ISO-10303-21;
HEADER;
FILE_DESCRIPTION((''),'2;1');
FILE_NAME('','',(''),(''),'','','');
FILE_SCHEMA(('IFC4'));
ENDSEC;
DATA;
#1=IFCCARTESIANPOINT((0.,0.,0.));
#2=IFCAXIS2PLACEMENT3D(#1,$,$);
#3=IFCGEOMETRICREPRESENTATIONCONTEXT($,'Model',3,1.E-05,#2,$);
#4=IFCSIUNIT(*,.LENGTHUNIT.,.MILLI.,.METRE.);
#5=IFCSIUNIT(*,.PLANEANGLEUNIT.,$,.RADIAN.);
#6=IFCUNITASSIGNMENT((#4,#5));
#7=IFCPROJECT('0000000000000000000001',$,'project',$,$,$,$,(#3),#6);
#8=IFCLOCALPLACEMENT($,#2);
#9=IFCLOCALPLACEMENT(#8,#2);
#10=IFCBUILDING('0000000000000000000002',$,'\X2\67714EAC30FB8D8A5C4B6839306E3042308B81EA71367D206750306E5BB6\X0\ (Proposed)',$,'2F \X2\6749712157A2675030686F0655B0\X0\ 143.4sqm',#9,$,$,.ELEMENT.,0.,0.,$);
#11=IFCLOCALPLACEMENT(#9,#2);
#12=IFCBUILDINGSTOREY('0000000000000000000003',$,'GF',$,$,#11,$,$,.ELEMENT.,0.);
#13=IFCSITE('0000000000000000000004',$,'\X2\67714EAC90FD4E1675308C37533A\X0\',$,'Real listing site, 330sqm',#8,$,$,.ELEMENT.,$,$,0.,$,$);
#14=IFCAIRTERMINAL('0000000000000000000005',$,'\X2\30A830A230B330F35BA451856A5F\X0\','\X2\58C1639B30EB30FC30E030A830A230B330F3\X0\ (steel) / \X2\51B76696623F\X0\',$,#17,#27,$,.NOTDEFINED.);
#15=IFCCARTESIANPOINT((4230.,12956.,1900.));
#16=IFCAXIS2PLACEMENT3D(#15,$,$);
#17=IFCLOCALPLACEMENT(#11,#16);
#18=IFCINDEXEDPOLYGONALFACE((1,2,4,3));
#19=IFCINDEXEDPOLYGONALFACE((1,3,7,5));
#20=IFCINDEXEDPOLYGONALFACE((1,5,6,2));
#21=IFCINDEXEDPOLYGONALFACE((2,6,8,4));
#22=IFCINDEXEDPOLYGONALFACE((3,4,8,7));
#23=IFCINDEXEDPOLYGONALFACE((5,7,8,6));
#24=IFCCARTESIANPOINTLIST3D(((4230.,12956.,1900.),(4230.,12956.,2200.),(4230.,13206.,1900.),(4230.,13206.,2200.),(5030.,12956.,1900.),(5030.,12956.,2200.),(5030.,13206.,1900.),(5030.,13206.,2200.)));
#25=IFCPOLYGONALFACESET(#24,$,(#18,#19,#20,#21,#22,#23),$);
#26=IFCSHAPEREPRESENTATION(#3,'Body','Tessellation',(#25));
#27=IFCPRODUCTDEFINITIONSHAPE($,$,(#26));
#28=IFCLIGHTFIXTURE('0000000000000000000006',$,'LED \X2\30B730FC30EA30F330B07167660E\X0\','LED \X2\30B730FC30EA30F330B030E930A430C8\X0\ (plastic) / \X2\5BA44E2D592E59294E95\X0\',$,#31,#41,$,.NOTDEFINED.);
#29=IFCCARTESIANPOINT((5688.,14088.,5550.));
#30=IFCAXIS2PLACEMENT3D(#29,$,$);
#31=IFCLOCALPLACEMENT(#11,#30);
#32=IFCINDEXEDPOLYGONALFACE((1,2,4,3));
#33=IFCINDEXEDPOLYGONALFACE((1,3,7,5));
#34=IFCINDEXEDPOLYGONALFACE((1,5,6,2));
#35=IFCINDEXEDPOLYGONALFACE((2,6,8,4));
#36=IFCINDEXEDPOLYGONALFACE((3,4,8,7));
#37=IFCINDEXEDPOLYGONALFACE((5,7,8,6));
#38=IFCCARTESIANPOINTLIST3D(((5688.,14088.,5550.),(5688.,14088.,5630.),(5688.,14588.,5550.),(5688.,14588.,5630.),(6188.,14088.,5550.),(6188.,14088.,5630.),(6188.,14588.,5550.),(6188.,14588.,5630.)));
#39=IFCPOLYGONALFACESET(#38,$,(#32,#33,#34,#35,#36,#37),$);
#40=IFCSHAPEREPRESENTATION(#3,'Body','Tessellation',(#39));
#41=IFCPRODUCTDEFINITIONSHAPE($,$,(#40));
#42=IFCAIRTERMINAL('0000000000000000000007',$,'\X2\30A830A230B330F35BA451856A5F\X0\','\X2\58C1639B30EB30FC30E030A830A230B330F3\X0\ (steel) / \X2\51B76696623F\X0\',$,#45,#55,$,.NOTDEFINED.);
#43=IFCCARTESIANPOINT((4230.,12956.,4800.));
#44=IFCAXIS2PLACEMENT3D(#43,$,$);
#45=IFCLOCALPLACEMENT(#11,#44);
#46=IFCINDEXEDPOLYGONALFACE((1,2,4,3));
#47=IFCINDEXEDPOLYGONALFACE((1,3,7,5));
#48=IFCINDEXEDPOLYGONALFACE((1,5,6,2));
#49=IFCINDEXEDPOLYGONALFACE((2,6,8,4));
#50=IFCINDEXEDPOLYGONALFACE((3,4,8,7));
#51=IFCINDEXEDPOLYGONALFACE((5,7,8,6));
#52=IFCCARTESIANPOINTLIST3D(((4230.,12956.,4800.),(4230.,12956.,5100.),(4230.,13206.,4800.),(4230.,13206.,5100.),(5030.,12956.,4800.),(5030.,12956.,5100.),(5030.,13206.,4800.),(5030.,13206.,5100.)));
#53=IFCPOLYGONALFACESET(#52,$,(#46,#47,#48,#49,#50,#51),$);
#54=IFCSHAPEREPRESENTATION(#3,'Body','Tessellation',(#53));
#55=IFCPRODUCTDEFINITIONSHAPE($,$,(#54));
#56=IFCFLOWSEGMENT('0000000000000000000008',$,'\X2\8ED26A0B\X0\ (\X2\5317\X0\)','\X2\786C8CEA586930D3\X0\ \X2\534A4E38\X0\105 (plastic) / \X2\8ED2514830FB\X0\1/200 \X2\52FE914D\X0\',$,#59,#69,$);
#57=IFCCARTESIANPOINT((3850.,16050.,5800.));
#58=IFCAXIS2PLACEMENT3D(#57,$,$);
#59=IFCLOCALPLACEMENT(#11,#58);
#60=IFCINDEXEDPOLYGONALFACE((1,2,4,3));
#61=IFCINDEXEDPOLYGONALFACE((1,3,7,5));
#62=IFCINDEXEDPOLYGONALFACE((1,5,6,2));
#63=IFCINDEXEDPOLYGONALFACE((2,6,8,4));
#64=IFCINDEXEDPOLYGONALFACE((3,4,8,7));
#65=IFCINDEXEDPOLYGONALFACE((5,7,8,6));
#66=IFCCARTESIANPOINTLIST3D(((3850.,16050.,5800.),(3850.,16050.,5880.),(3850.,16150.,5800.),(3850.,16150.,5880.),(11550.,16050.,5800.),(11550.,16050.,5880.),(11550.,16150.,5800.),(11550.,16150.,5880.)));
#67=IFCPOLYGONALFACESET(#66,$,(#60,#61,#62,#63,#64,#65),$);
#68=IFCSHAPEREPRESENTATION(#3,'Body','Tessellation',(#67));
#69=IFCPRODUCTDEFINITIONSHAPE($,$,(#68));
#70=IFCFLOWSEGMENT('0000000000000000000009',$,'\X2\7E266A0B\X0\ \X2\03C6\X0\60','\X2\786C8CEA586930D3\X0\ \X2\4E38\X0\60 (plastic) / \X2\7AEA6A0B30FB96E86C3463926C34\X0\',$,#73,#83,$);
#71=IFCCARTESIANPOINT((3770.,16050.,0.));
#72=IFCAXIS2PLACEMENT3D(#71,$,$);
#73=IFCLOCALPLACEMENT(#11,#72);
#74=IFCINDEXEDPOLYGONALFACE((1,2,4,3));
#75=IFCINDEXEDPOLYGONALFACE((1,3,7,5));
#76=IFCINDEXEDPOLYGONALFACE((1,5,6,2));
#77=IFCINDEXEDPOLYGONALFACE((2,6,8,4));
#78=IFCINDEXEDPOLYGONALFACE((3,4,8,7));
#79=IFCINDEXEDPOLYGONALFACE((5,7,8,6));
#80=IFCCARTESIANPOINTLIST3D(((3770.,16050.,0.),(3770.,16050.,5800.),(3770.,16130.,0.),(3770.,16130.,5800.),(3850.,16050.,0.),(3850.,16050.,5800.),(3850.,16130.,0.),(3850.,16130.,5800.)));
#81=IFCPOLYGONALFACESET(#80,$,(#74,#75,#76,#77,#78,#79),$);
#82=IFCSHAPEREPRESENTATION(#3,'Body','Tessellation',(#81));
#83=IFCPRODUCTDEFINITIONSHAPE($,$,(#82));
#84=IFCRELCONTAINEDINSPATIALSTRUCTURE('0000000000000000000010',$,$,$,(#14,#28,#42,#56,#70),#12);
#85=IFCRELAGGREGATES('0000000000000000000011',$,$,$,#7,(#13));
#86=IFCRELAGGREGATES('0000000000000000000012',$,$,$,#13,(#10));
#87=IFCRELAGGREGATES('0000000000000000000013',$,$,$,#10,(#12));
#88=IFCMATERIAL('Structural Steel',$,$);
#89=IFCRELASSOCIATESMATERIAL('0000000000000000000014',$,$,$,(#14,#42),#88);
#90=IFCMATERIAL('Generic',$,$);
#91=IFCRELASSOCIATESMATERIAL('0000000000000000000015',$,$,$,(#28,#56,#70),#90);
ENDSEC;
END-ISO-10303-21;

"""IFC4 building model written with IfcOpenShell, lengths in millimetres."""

from ifc_helpers import new_model, si_unit, frame, frame_2d, origin, place, context, project, spatial, rectangle, extrude, material, element, save


model = new_model("IFC4")

# Units and contexts
model_context = context("Model", 3, precision=1e-05, world=origin())
ifc_project = project(units=[si_unit("LENGTHUNIT", "METRE", prefix="MILLI"), si_unit("PLANEANGLEUNIT", "RADIAN")], contexts=[model_context])

# Site, building, storey
site_placement = place(None, origin())
site = spatial("IfcSite", under=ifc_project, at=site_placement, Name="東京都世田谷区", ObjectType="Real listing site, 330sqm", CompositionType="ELEMENT", RefElevation=0.0)
building_placement = place(site_placement, origin())
building = spatial("IfcBuilding", under=site, at=building_placement, Name="東京・越屋根のある自然素材の家 (Proposed)", ObjectType="2F 杉無垢材と漆喰 143.4sqm", CompositionType="ELEMENT", ElevationOfRefHeight=0.0, ElevationOfTerrain=0.0)
storey_placement = place(building_placement, origin())
storey = spatial("IfcBuildingStorey", under=building, at=storey_placement, Name="GF", CompositionType="ELEMENT", Elevation=0.0)

# Shared definitions
ifc_material_1 = material(Name="Generic")

# Shared definitions
ifc_material_2 = material(Name="Structural Steel")

# Air terminal
air_terminal_1_placement = place(storey_placement, frame((4230.0, 12956.0, 1900.0)))
element("IfcAirTerminal", 1, at=air_terminal_1_placement, inside=storey, material=ifc_material_2, Name="エアコン室内機", Description="壁掛ルームエアコン (steel) / 冷暖房", PredefinedType="NOTDEFINED", context=model_context, shape_type="SweptSolid", body=[
    extrude(rectangle(XDim=800.0, YDim=250.0, at=frame_2d((400.0, 125.0))), frame((4230.0, 12956.0, 1900.0)), (0.0, 0.0, 1.0), 300.0),
])

# Light fixture
light_fixture_placement = place(storey_placement, frame((5688.0, 14088.0, 5550.0)))
element("IfcLightFixture", 2, at=light_fixture_placement, inside=storey, material=ifc_material_1, Name="LED シーリング照明", Description="LED シーリングライト (plastic) / 室中央天井", PredefinedType="NOTDEFINED", context=model_context, shape_type="SweptSolid", body=[
    extrude(rectangle(XDim=500.0, YDim=500.0, at=frame_2d((250.0, 250.0))), frame((5688.0, 14088.0, 5550.0)), (0.0, 0.0, 1.0), 80.0),
])

# Air terminal
air_terminal_2_placement = place(storey_placement, frame((4230.0, 12956.0, 4800.0)))
element("IfcAirTerminal", 3, at=air_terminal_2_placement, inside=storey, material=ifc_material_2, Name="エアコン室内機", Description="壁掛ルームエアコン (steel) / 冷暖房", PredefinedType="NOTDEFINED", context=model_context, shape_type="SweptSolid", body=[
    extrude(rectangle(XDim=800.0, YDim=250.0, at=frame_2d((400.0, 125.0))), frame((4230.0, 12956.0, 4800.0)), (0.0, 0.0, 1.0), 300.0),
])

# Flow segments
flow_segment_1_placement = place(storey_placement, frame((3850.0, 16050.0, 5800.0)))
element("IfcFlowSegment", 4, at=flow_segment_1_placement, inside=storey, material=ifc_material_1, Name="軒樋 (北)", Description="硬質塩ビ 半丸105 (plastic) / 軒先・1/200 勾配", context=model_context, shape_type="SweptSolid", body=[
    extrude(rectangle(XDim=7700.0, YDim=100.0, at=frame_2d((3850.0, 50.0))), frame((3850.0, 16050.0, 5800.0)), (0.0, 0.0, 1.0), 80.0),
])
flow_segment_2_placement = place(storey_placement, frame((3770.0, 16050.0, 0.0)))
element("IfcFlowSegment", 5, at=flow_segment_2_placement, inside=storey, material=ifc_material_1, Name="縦樋 φ60", Description="硬質塩ビ 丸60 (plastic) / 竪樋・雨水排水", context=model_context, shape_type="SweptSolid", body=[
    extrude(rectangle(XDim=80.0, YDim=80.0, at=frame_2d((40.0, 40.0))), frame((3770.0, 16050.0, 0.0)), (0.0, 0.0, 1.0), 5800.0),
])

save(model, "model.ifc")
